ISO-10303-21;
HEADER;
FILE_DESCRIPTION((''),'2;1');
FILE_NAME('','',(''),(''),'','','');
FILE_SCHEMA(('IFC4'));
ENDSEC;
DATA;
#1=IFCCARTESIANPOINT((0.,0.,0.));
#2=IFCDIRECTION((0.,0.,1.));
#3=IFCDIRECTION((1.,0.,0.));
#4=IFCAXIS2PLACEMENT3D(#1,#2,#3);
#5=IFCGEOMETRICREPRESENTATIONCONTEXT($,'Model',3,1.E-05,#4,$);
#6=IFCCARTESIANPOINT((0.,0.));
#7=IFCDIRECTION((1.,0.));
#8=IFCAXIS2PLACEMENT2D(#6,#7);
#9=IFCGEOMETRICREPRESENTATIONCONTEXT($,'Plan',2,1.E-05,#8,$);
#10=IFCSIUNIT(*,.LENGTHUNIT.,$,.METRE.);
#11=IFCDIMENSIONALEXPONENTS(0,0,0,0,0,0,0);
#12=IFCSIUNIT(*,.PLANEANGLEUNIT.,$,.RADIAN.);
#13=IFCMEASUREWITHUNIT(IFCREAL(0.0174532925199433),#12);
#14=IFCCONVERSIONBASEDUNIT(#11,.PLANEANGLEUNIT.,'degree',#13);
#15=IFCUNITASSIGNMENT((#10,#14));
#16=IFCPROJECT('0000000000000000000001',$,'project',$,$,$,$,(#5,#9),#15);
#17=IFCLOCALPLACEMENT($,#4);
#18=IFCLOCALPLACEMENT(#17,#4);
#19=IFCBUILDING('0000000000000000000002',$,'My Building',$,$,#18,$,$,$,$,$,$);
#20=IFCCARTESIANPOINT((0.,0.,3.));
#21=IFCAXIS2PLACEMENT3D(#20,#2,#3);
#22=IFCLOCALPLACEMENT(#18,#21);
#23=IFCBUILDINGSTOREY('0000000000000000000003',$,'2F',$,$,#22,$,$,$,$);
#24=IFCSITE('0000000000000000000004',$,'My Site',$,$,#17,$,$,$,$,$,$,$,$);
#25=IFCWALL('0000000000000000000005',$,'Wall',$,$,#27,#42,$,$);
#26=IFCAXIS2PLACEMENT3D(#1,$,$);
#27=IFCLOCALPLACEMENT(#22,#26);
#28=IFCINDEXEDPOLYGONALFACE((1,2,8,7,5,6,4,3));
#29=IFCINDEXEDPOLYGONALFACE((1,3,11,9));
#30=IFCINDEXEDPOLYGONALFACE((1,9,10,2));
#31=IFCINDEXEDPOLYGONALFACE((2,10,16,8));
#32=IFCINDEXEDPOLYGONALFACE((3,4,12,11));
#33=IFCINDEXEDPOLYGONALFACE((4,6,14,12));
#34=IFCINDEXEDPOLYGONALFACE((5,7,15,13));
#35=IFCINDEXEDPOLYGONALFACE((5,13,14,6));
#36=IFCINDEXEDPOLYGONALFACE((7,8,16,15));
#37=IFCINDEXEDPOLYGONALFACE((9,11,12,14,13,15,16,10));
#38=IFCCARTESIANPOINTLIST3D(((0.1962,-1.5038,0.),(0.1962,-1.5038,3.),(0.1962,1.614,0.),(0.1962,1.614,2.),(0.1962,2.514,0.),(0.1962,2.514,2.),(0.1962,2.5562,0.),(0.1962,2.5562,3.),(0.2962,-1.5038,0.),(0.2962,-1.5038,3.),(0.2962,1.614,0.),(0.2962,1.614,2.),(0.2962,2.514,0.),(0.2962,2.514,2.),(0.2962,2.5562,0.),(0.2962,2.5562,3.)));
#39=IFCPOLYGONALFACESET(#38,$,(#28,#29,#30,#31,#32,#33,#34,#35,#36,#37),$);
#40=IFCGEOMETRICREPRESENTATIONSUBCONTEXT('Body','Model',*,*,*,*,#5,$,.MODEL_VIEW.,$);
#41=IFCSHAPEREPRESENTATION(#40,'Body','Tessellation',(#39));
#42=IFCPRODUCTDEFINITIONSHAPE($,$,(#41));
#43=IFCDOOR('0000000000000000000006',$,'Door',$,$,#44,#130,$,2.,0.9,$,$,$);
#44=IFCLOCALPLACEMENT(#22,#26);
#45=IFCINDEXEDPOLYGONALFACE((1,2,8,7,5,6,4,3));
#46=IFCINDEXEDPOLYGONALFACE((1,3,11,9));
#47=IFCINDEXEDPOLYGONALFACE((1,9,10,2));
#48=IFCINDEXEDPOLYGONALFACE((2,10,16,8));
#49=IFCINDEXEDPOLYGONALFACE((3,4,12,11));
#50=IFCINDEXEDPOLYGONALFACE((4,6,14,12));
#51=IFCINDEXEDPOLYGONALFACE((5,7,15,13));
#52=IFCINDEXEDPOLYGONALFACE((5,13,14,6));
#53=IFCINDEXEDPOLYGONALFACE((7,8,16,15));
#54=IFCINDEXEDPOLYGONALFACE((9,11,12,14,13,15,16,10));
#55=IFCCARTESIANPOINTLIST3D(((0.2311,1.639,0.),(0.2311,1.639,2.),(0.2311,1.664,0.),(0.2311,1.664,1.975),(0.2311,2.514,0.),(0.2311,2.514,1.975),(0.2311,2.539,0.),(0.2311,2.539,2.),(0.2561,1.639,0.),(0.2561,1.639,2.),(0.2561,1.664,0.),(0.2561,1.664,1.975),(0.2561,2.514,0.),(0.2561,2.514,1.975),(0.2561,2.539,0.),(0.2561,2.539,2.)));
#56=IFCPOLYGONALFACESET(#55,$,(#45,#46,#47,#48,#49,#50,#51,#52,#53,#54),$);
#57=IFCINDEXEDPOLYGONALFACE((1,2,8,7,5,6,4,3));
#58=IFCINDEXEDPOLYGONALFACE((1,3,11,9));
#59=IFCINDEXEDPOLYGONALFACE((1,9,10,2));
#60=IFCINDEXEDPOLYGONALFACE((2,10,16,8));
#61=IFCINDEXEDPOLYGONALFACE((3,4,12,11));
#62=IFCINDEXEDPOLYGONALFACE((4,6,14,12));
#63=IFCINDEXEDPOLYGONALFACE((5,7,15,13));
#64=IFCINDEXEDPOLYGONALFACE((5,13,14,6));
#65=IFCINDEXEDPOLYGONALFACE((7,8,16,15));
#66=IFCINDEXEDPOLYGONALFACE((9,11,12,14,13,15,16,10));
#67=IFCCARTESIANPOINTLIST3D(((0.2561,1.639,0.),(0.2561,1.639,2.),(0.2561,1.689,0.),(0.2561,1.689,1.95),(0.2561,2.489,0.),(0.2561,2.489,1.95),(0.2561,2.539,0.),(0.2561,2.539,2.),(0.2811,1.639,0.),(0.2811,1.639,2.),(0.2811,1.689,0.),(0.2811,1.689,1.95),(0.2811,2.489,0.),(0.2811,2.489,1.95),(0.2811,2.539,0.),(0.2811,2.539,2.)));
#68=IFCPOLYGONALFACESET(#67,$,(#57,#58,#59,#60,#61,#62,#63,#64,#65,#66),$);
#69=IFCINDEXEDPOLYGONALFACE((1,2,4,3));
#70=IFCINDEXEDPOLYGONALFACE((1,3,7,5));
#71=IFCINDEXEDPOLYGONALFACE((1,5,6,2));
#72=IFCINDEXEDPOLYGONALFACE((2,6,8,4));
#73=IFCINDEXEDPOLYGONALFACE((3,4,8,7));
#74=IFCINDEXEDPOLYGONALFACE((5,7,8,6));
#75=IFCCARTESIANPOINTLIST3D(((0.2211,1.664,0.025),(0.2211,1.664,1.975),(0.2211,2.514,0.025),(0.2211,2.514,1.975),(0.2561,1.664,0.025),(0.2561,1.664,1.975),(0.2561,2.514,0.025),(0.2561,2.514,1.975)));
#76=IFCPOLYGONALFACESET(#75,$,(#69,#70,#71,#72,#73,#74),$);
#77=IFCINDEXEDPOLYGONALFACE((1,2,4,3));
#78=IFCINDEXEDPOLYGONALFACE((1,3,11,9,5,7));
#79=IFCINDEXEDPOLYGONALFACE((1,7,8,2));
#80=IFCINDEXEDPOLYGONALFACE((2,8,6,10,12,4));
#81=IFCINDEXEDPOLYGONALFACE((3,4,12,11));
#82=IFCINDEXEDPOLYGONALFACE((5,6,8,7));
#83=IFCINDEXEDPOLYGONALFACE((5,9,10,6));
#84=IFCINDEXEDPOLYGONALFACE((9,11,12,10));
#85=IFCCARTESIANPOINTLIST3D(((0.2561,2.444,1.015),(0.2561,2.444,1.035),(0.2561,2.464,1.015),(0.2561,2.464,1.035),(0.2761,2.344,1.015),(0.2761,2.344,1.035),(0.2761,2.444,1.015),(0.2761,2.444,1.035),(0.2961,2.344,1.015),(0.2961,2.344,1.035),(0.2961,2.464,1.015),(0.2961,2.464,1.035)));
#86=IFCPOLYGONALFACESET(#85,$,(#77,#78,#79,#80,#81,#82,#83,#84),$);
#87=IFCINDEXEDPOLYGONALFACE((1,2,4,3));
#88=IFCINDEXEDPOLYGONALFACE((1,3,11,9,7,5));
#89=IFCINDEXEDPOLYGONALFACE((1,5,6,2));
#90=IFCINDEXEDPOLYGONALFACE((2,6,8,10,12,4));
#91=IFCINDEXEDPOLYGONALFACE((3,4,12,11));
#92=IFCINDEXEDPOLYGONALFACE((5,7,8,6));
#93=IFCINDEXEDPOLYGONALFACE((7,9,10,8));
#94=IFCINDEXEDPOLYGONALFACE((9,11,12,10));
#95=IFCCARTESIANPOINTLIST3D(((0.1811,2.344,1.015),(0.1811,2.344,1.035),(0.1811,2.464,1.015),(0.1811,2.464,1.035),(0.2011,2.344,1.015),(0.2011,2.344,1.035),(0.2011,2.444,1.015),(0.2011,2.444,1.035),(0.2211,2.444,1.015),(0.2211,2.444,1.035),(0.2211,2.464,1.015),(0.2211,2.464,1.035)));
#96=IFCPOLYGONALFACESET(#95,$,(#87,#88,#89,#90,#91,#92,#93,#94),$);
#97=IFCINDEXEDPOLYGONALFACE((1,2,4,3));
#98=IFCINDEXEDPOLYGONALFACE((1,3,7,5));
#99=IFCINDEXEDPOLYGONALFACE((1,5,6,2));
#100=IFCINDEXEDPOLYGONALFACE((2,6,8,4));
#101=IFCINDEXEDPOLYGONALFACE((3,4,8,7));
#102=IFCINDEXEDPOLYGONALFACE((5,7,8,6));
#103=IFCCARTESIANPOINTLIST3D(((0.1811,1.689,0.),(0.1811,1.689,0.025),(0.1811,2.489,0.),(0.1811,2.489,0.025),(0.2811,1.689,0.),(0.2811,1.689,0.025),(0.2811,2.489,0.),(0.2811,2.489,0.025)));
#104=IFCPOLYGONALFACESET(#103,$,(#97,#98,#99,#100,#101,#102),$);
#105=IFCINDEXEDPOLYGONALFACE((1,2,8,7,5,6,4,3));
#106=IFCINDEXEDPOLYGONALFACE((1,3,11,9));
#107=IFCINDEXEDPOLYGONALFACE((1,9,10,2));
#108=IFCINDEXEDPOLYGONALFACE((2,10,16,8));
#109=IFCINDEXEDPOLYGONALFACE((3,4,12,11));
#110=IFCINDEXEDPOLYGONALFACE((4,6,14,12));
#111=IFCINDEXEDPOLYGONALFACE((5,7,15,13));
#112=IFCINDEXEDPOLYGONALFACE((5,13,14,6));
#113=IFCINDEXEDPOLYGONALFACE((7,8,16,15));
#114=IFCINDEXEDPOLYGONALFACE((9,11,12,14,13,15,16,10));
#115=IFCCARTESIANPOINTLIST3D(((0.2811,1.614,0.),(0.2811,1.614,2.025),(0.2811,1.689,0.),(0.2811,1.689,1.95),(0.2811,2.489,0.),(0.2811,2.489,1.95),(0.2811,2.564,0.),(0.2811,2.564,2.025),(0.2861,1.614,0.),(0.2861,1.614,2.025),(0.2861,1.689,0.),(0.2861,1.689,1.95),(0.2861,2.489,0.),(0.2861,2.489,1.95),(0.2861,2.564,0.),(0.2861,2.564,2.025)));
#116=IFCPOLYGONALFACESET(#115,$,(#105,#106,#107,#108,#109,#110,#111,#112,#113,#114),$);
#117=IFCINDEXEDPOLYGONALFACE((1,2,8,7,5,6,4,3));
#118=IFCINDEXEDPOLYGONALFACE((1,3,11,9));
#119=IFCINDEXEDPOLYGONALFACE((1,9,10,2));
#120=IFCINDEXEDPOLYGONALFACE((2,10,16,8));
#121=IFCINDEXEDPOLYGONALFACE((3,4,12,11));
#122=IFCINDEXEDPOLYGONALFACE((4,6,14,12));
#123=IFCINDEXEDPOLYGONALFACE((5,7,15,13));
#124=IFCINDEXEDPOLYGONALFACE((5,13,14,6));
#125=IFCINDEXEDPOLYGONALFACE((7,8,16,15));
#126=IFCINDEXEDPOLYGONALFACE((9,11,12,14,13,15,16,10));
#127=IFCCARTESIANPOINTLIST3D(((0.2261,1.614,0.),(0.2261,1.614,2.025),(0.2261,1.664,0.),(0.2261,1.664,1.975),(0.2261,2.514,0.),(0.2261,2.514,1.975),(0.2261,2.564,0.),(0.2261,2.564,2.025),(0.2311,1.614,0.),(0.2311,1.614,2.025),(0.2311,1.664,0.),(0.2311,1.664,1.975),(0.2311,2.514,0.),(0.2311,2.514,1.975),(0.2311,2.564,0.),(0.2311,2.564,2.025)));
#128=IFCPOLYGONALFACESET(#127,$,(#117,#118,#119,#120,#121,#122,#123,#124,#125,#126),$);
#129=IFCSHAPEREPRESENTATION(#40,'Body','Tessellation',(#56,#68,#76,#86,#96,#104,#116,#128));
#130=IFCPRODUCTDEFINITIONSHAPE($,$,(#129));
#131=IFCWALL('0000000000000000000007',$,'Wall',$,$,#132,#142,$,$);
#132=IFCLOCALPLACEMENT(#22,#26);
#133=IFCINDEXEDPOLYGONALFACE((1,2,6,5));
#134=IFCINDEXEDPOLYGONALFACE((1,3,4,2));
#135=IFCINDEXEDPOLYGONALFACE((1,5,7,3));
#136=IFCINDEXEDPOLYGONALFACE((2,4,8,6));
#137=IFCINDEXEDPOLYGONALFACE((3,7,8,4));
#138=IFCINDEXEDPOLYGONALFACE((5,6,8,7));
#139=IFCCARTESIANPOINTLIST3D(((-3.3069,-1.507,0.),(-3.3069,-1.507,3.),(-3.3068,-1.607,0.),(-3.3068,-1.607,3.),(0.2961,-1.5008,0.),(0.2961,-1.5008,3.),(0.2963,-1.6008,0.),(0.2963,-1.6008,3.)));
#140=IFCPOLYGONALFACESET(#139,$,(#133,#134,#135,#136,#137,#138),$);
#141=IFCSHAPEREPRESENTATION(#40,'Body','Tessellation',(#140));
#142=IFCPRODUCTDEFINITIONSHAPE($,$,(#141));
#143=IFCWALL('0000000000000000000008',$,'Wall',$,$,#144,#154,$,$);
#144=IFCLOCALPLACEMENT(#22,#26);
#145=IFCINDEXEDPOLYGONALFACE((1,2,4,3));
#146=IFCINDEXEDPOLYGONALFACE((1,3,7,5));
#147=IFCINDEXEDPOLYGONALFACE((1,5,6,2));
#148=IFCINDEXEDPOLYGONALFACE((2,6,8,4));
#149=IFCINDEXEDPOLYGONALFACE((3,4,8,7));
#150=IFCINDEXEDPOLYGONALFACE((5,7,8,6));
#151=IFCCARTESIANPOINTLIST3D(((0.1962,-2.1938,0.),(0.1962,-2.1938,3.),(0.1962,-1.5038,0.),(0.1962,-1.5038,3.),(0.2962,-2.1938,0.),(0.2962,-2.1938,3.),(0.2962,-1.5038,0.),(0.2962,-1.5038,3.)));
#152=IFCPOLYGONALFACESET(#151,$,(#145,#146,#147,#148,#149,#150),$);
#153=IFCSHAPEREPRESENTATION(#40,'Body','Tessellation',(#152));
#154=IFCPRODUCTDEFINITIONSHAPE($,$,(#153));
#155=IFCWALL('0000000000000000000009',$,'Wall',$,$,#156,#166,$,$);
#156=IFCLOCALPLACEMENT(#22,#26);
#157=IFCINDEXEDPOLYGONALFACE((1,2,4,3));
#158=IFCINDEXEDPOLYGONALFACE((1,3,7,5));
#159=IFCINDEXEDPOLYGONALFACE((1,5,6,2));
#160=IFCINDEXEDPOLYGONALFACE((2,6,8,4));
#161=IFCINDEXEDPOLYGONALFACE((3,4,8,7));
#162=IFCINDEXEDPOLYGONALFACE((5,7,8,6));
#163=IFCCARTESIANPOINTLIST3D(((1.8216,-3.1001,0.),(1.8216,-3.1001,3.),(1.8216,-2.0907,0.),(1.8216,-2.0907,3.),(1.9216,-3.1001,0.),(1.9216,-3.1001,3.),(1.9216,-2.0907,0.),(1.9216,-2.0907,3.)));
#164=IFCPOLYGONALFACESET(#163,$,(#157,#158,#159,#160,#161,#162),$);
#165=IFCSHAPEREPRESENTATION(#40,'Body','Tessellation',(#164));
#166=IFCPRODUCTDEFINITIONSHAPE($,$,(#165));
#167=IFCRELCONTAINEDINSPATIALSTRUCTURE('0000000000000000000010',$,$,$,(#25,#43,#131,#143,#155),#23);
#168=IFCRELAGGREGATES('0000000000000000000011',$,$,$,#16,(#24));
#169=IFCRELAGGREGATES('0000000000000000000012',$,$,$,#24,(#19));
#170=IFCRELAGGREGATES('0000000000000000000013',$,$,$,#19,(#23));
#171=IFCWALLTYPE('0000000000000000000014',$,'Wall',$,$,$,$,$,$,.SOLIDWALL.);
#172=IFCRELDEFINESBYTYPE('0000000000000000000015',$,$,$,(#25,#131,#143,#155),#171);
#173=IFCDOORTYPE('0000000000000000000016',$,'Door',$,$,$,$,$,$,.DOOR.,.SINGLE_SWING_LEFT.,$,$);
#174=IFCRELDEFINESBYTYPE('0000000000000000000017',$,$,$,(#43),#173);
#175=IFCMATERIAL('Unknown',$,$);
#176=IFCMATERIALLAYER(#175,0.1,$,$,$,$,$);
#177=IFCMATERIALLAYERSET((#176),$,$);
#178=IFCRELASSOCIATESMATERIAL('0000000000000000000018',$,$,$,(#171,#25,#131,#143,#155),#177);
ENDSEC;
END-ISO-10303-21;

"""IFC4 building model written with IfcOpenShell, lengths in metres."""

from ifc_helpers import new_model, entity, si_unit, converted_unit, frame, origin_with_axes, origin_2d_with_axis, place, context, subcontext, project, spatial, line, indexed_curve, outline, extrude, shape, source, transform, mapped, material, layer, layer_set, layer_usage, type_object, type_shapes, element, fill, save


model = new_model("IFC4")

# Units and contexts
model_context = context("Model", 3, precision=1e-05, world=origin_with_axes())
plan_context = context("Plan", 2, precision=1e-05, world=origin_2d_with_axis())
body_context_1 = subcontext(model_context, "Body", "Model", "MODEL_VIEW")
body_context_2 = subcontext(plan_context, "Body", "Plan", "PLAN_VIEW")
ifc_project = project(units=[si_unit("LENGTHUNIT", "METRE"), converted_unit("PLANEANGLEUNIT", "degree", entity("IfcReal", 0.0174532925199433), si_unit("PLANEANGLEUNIT", "RADIAN"), dimensions=[0, 0, 0, 0, 0, 0, 0])], contexts=[model_context, plan_context])

# Site, building, storey
site_placement = place(None, origin_with_axes())
site = spatial("IfcSite", under=ifc_project, at=site_placement, Name="My Site")
building_placement = place(site_placement, origin_with_axes())
building = spatial("IfcBuilding", under=site, at=building_placement, Name="My Building")
storey_placement = place(building_placement, frame((0.0, 0.0, 3.0), z_axis=(0.0, 0.0, 1.0), x_axis=(1.0, 0.0, 0.0)))
storey = spatial("IfcBuildingStorey", under=building, at=storey_placement, Name="2F")

# Shared definitions
ifc_material = material(Name="Unknown")

# Shared definitions
ifc_layer_1 = layer(ifc_material, 0.1)
ifc_layer_set_1 = layer_set([ifc_layer_1])
wall_type = type_object("IfcWallType", Name="Wall", PredefinedType="SOLIDWALL", material=ifc_layer_set_1)

# Wall, opening, door
shared_shape_1 = source(origin_with_axes(), body_context_1, "Body", "SweptSolid", [
    extrude(outline(indexed_curve([(0.0, 0.0), (0.9, 0.0), (0.9, 2.0), (0.0, 2.0)], segments=[line(1, 2, 3, 4, 1)])), frame((0.0, -0.6, 0.0), z_axis=(0.0, -1.0, 0.0), x_axis=(1.0, 0.0, 0.0)), (0.0, 0.0, -1.0), 1.2),
])
door_type_1 = type_object("IfcDoorType", Name="Door", OperationType="SINGLE_SWING_LEFT", PredefinedType="DOOR")
shared_shape_2 = source(origin_with_axes(), body_context_1, "Body", "SweptSolid", [
    extrude(outline(indexed_curve([(0.0, 0.0), (0.0, 2.0), (0.9, 2.0), (0.9, 0.0), (0.875, 0.0), (0.875, 1.975), (0.025, 1.975), (0.025, 0.0)], segments=[line(1, 2, 3, 4, 5, 6, 7, 8, 1)])), frame((0.0, 0.025, 0.0), z_axis=(0.0, -1.0, 0.0), x_axis=(1.0, 0.0, 0.0)), (0.0, 0.0, -1.0), 0.025),
    extrude(outline(indexed_curve([(0.0, 0.0), (0.0, 2.0), (0.9, 2.0), (0.9, 0.0), (0.85, 0.0), (0.85, 1.95), (0.05, 1.95), (0.05, 0.0)], segments=[line(1, 2, 3, 4, 5, 6, 7, 8, 1)])), frame((0.0, 0.0, 0.0), z_axis=(0.0, -1.0, 0.0), x_axis=(1.0, 0.0, 0.0)), (0.0, 0.0, -1.0), 0.025),
    extrude(outline(indexed_curve([(0.0, 0.0), (0.85, 0.0), (0.85, 0.035), (0.0, 0.035)], segments=[line(1, 2, 3, 4, 1)])), frame((0.025, 0.025, 0.025), z_axis=(0.0, 0.0, 1.0), x_axis=(1.0, 0.0, 0.0)), (0.0, 0.0, 1.0), 1.95),
    extrude(outline(indexed_curve([(0.0, 0.0), (0.0, -0.04), (-0.12, -0.04), (-0.12, -0.02), (-0.02, -0.02), (-0.02, 0.0)], segments=[line(1, 2, 3, 4, 5, 6, 1)])), frame((0.825, 0.025, 1.015), z_axis=(0.0, 0.0, 1.0), x_axis=(1.0, 0.0, 0.0)), (0.0, 0.0, 1.0), 0.02),
    extrude(outline(indexed_curve([(0.0, 0.0), (0.0, 0.04), (-0.12, 0.04), (-0.12, 0.02), (-0.02, 0.02), (-0.02, 0.0)], segments=[line(1, 2, 3, 4, 5, 6, 1)])), frame((0.825, 0.06, 1.015), z_axis=(0.0, 0.0, 1.0), x_axis=(1.0, 0.0, 0.0)), (0.0, 0.0, 1.0), 0.02),
    extrude(outline(indexed_curve([(0.0, 0.0), (0.8, 0.0), (0.8, 0.1), (0.0, 0.1)], segments=[line(1, 2, 3, 4, 1)])), frame((0.05, 0.0, 0.0), z_axis=(0.0, 0.0, 1.0), x_axis=(1.0, 0.0, 0.0)), (0.0, 0.0, 1.0), 0.025),
    extrude(outline(indexed_curve([(0.0, 0.0), (0.0, 2.025), (0.95, 2.025), (0.95, 0.0), (0.875, 0.0), (0.875, 1.95), (0.075, 1.95), (0.075, 0.0)], segments=[line(1, 2, 3, 4, 5, 6, 7, 8, 1)])), frame((-0.025, -0.005, 0.0), z_axis=(0.0, -1.0, 0.0), x_axis=(1.0, 0.0, 0.0)), (0.0, 0.0, -1.0), 0.005),
    extrude(outline(indexed_curve([(0.0, 0.0), (0.0, 2.025), (0.95, 2.025), (0.95, 0.0), (0.9, 0.0), (0.9, 1.975), (0.05, 1.975), (0.05, 0.0)], segments=[line(1, 2, 3, 4, 5, 6, 7, 8, 1)])), frame((-0.025, 0.05, 0.0), z_axis=(0.0, -1.0, 0.0), x_axis=(1.0, 0.0, 0.0)), (0.0, 0.0, -1.0), 0.005),
])
shared_shape_3 = source(origin_with_axes(), body_context_2, "Body", "Curve2D", [
    entity("IfcIndexedPolyCurve", entity("IfcCartesianPointList2D", [[0.0, 0.0], [0.0, 0.05], [0.025, 0.05], [0.025, 0.025], [0.05, 0.025], [0.05, 0.0]]), [entity("IfcLineIndex", [1, 2, 3, 4, 5, 6, 1])]),
    entity("IfcIndexedPolyCurve", entity("IfcCartesianPointList2D", [[0.9, 0.0], [0.9, 0.05], [0.875, 0.05], [0.875, 0.025], [0.85, 0.025], [0.85, 0.0]]), [entity("IfcLineIndex", [1, 2, 3, 4, 5, 6, 1])]),
    entity("IfcTrimmedCurve", entity("IfcEllipse", entity("IfcAxis2Placement2D", entity("IfcCartesianPoint", [0.06, 0.05]), entity("IfcDirection", [1.0, 0.0])), 0.815, 0.85), [entity("IfcCartesianPoint", [0.875, 0.05])], [entity("IfcCartesianPoint", [0.06, 0.9])], True, "CARTESIAN"),
    entity("IfcIndexedPolyCurve", entity("IfcCartesianPointList2D", [[0.025, 0.05], [0.06, 0.05], [0.06, 0.9], [0.025, 0.9]]), [entity("IfcLineIndex", [1, 2, 3, 4, 1])]),
])
type_shapes(door_type_1, [shared_shape_2, shared_shape_3])
ifc_layer_usage_1 = layer_usage(ifc_layer_set_1, "AXIS2", "POSITIVE", 0.0)
wall_1_placement = place(storey_placement, frame((0.2962, -1.5038, 0.0), z_axis=(0.0, 0.0, 1.0), x_axis=(0.0, 1.0, 0.0)))
wall_1 = element("IfcWall", 1, at=wall_1_placement, inside=storey, type_object=wall_type, material=ifc_layer_usage_1, Name="Wall", context=body_context_1, shape_type="SweptSolid", body=[
    extrude(outline(indexed_curve([(0.0, 0.0), (0.0, 0.1), (4.06, 0.1), (4.06, 0.0)], segments=[line(1, 2, 3, 4, 1)])), origin_with_axes(), (0.0, 0.0, 1.0), 3.0),
])
opening_1_placement = place(wall_1_placement, frame((3.1178, 0.0, 0.0), z_axis=(0.0, 0.0, 1.0), x_axis=(1.0, 0.0, 0.0)))
opening_1 = element("IfcOpeningElement", 2, at=opening_1_placement, cuts=wall_1, PredefinedType="OPENING", context=body_context_1, shape_type="MappedRepresentation", body=[
    mapped(shared_shape_1, transform((0.0, 0.0, 0.0), x_axis=(1.0, 0.0, 0.0), y_axis=(0.0, 1.0, 0.0), z_axis=(0.0, 0.0, 1.0), scale=1.0)),
])
door_1_placement = place(opening_1_placement, frame((0.025, 0.0151, 0.0), z_axis=(0.0, 0.0, 1.0), x_axis=(1.0, 0.0, 0.0)))
door_1 = element("IfcDoor", 3, at=door_1_placement, inside=storey, type_object=door_type_1, Name="Door", OverallHeight=2.0, OverallWidth=0.9, shapes=[
    shape(body_context_1, "Body", "MappedRepresentation", [mapped(shared_shape_2, transform((0.0, 0.0, 0.0), x_axis=(1.0, 0.0, 0.0), y_axis=(0.0, 1.0, 0.0), z_axis=(0.0, 0.0, 1.0), scale=1.0))]),
    shape(body_context_2, "Body", "MappedRepresentation", [mapped(shared_shape_3, transform((0.0, 0.0, 0.0), x_axis=(1.0, 0.0, 0.0), y_axis=(0.0, 1.0, 0.0), z_axis=(0.0, 0.0, 1.0), scale=1.0))]),
])
fill(opening_1, door_1)

# Walls
ifc_layer_usage_2 = layer_usage(ifc_layer_set_1, "AXIS2", "POSITIVE", 0.0)
wall_2_placement = place(storey_placement, frame((-3.3068, -1.607, 0.0), z_axis=(0.0, 0.0, 1.0), x_axis=(0.999999, 0.001712, 0.0)))
element("IfcWall", 4, at=wall_2_placement, inside=storey, type_object=wall_type, material=ifc_layer_usage_2, Name="Wall", context=body_context_1, shape_type="SweptSolid", body=[
    extrude(outline(indexed_curve([(0.0, 0.0), (0.0, 0.1), (3.6031, 0.1), (3.6031, 0.0)], segments=[line(1, 2, 3, 4, 1)])), origin_with_axes(), (0.0, 0.0, 1.0), 3.0),
])
ifc_layer_usage_3 = layer_usage(ifc_layer_set_1, "AXIS2", "POSITIVE", 0.0)
wall_3_placement = place(storey_placement, frame((0.1962, -1.5038, 0.0), z_axis=(0.0, 0.0, 1.0), x_axis=(0.0, -1.0, 0.0)))
element("IfcWall", 5, at=wall_3_placement, inside=storey, type_object=wall_type, material=ifc_layer_usage_3, Name="Wall", context=body_context_1, shape_type="SweptSolid", body=[
    extrude(outline(indexed_curve([(0.0, 0.0), (0.0, 0.1), (0.69, 0.1), (0.69, 0.0)], segments=[line(1, 2, 3, 4, 1)])), origin_with_axes(), (0.0, 0.0, 1.0), 3.0),
])
ifc_layer_usage_4 = layer_usage(ifc_layer_set_1, "AXIS2", "POSITIVE", 0.0)
wall_4_placement = place(storey_placement, frame((1.9216, -3.1001, 0.0), z_axis=(0.0, 0.0, 1.0), x_axis=(0.000002, 1.0, 0.0)))
element("IfcWall", 6, at=wall_4_placement, inside=storey, type_object=wall_type, material=ifc_layer_usage_4, Name="Wall", context=body_context_1, shape_type="SweptSolid", body=[
    extrude(outline(indexed_curve([(0.0, 0.0), (0.0, 0.1), (1.0094, 0.1), (1.0094, 0.0)], segments=[line(1, 2, 3, 4, 1)])), origin_with_axes(), (0.0, 0.0, 1.0), 3.0),
])

save(model, "model.ifc")
